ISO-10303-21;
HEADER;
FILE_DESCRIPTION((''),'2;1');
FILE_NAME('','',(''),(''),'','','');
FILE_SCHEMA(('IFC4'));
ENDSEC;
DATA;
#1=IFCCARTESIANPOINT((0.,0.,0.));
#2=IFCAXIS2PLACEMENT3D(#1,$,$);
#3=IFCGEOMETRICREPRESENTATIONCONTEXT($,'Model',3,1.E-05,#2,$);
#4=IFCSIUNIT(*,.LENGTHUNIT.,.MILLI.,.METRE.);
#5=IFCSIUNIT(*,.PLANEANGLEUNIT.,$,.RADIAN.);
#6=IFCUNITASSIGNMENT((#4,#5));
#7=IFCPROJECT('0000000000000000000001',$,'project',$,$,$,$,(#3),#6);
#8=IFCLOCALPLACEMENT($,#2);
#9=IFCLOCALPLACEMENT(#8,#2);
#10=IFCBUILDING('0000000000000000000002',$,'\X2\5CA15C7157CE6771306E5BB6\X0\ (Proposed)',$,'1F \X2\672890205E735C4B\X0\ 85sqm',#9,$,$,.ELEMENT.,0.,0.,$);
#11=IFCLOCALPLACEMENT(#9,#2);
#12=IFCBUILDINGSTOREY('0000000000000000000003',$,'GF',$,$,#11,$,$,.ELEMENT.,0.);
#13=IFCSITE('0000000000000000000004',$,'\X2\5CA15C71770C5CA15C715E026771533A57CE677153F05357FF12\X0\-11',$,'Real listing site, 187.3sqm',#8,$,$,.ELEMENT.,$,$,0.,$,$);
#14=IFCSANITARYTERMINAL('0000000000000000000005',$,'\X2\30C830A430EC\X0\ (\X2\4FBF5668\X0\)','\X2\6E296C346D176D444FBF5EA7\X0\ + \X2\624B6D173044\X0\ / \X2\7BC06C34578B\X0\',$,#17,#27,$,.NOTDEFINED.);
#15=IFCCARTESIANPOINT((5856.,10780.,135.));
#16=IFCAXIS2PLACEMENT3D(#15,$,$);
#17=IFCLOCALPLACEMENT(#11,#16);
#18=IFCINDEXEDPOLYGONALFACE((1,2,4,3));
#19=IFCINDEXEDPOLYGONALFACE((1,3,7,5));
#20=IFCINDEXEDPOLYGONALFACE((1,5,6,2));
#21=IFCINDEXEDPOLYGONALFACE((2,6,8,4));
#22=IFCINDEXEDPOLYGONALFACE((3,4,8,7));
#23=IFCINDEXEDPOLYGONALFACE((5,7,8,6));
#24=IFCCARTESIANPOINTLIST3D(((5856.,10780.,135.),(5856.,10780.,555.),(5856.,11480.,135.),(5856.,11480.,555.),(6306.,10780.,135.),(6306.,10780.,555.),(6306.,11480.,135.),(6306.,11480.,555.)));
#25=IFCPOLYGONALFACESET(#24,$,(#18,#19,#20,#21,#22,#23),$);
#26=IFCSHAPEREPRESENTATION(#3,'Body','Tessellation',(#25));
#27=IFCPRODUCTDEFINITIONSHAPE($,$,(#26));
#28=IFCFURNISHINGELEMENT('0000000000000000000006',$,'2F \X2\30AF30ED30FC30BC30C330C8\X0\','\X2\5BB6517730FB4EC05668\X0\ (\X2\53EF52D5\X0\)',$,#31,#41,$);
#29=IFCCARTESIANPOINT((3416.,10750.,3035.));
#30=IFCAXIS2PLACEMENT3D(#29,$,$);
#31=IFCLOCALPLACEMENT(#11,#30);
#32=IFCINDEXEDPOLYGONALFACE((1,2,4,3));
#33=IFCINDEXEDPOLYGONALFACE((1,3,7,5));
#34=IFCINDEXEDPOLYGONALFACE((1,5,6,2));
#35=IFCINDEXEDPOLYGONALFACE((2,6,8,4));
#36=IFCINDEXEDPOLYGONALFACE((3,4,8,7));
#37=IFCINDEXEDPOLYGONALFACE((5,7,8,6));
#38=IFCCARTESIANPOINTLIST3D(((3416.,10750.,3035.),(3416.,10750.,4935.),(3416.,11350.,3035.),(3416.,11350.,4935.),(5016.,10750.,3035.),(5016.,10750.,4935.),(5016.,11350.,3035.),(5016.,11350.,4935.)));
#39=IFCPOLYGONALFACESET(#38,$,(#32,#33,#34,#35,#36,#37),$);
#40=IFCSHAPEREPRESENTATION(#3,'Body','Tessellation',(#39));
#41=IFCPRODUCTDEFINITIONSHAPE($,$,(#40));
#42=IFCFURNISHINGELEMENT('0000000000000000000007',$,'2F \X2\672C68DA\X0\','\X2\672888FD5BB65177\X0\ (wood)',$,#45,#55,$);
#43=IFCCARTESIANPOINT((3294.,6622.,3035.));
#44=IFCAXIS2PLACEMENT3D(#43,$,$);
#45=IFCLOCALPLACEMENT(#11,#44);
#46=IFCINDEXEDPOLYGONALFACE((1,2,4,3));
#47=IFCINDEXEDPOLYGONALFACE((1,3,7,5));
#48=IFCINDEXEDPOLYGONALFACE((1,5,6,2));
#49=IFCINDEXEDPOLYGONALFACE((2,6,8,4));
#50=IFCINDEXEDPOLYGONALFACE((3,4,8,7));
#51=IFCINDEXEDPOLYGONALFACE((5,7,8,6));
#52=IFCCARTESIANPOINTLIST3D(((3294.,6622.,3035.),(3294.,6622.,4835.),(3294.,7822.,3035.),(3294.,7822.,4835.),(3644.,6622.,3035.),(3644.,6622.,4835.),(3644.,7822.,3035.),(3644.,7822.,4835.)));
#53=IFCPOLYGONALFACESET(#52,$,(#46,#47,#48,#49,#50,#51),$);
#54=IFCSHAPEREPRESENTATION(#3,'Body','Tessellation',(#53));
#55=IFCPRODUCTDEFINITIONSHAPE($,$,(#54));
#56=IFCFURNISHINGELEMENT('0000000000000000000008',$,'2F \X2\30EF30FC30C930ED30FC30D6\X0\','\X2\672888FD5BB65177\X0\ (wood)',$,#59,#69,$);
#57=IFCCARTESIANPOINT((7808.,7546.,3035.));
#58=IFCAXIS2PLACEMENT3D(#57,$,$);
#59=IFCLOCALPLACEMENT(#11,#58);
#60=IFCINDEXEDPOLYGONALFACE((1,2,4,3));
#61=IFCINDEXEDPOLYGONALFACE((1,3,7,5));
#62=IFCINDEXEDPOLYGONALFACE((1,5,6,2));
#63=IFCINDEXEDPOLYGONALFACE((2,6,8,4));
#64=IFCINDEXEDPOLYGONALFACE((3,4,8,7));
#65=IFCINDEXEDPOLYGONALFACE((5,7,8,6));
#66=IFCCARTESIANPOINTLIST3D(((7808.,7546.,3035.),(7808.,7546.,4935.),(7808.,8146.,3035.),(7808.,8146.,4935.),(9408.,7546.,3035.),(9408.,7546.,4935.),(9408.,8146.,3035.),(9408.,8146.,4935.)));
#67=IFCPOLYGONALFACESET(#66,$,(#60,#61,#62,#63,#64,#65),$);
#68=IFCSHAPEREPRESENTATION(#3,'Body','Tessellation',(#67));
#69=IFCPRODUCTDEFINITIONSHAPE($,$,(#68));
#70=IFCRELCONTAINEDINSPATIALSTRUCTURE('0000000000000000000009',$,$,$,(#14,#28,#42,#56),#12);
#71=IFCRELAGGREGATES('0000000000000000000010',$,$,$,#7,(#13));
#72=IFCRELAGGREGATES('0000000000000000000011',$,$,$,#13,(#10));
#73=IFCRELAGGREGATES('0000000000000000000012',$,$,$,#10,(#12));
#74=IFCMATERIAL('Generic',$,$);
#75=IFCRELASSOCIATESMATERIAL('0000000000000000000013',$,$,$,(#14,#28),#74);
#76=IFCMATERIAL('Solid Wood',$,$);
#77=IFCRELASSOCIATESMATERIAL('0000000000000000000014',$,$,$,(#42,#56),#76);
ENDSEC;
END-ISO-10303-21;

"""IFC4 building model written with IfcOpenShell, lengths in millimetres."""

from ifc_helpers import new_model, si_unit, frame, frame_2d, origin, place, context, project, spatial, rectangle, extrude, material, element, save


model = new_model("IFC4")

# Units and contexts
model_context = context("Model", 3, precision=1e-05, world=origin())
ifc_project = project(units=[si_unit("LENGTHUNIT", "METRE", prefix="MILLI"), si_unit("PLANEANGLEUNIT", "RADIAN")], contexts=[model_context])

# Site, building, storey
site_placement = place(None, origin())
site = spatial("IfcSite", under=ifc_project, at=site_placement, Name="岡山県岡山市東区城東台南２-11", ObjectType="Real listing site, 187.3sqm", CompositionType="ELEMENT", RefElevation=0.0)
building_placement = place(site_placement, origin())
building = spatial("IfcBuilding", under=site, at=building_placement, Name="岡山城東の家 (Proposed)", ObjectType="1F 木造平屋 85sqm", CompositionType="ELEMENT", ElevationOfRefHeight=0.0, ElevationOfTerrain=0.0)
storey_placement = place(building_placement, origin())
storey = spatial("IfcBuildingStorey", under=building, at=storey_placement, Name="GF", CompositionType="ELEMENT", Elevation=0.0)

# Shared definitions
ifc_material_1 = material(Name="Solid Wood")

# Shared definitions
ifc_material_2 = material(Name="Generic")

# Sanitary terminal
sanitary_terminal_placement = place(storey_placement, frame((5856.0, 10780.0, 135.0)))
element("IfcSanitaryTerminal", 1, at=sanitary_terminal_placement, inside=storey, material=ifc_material_2, Name="トイレ (便器)", Description="温水洗浄便座 + 手洗い / 節水型", PredefinedType="NOTDEFINED", context=model_context, shape_type="SweptSolid", body=[
    extrude(rectangle(XDim=450.0, YDim=700.0, at=frame_2d((225.0, 350.0))), frame((5856.0, 10780.0, 135.0)), (0.0, 0.0, 1.0), 420.0),
])

# Furnishing elements
furnishing_1_placement = place(storey_placement, frame((3416.0, 10750.0, 3035.0)))
element("IfcFurnishingElement", 2, at=furnishing_1_placement, inside=storey, material=ifc_material_2, Name="2F クローゼット", Description="家具・什器 (可動)", context=model_context, shape_type="SweptSolid", body=[
    extrude(rectangle(XDim=1600.0, YDim=600.0, at=frame_2d((800.0, 300.0))), frame((3416.0, 10750.0, 3035.0)), (0.0, 0.0, 1.0), 1900.0),
])
furnishing_2_placement = place(storey_placement, frame((3294.0, 6622.0, 3035.0)))
element("IfcFurnishingElement", 3, at=furnishing_2_placement, inside=storey, material=ifc_material_1, Name="2F 本棚", Description="木製家具 (wood)", context=model_context, shape_type="SweptSolid", body=[
    extrude(rectangle(XDim=350.0, YDim=1200.0, at=frame_2d((175.0, 600.0))), frame((3294.0, 6622.0, 3035.0)), (0.0, 0.0, 1.0), 1800.0),
])
furnishing_3_placement = place(storey_placement, frame((7808.0, 7546.0, 3035.0)))
element("IfcFurnishingElement", 4, at=furnishing_3_placement, inside=storey, material=ifc_material_1, Name="2F ワードローブ", Description="木製家具 (wood)", context=model_context, shape_type="SweptSolid", body=[
    extrude(rectangle(XDim=1600.0, YDim=600.0, at=frame_2d((800.0, 300.0))), frame((7808.0, 7546.0, 3035.0)), (0.0, 0.0, 1.0), 1900.0),
])

save(model, "model.ifc")
